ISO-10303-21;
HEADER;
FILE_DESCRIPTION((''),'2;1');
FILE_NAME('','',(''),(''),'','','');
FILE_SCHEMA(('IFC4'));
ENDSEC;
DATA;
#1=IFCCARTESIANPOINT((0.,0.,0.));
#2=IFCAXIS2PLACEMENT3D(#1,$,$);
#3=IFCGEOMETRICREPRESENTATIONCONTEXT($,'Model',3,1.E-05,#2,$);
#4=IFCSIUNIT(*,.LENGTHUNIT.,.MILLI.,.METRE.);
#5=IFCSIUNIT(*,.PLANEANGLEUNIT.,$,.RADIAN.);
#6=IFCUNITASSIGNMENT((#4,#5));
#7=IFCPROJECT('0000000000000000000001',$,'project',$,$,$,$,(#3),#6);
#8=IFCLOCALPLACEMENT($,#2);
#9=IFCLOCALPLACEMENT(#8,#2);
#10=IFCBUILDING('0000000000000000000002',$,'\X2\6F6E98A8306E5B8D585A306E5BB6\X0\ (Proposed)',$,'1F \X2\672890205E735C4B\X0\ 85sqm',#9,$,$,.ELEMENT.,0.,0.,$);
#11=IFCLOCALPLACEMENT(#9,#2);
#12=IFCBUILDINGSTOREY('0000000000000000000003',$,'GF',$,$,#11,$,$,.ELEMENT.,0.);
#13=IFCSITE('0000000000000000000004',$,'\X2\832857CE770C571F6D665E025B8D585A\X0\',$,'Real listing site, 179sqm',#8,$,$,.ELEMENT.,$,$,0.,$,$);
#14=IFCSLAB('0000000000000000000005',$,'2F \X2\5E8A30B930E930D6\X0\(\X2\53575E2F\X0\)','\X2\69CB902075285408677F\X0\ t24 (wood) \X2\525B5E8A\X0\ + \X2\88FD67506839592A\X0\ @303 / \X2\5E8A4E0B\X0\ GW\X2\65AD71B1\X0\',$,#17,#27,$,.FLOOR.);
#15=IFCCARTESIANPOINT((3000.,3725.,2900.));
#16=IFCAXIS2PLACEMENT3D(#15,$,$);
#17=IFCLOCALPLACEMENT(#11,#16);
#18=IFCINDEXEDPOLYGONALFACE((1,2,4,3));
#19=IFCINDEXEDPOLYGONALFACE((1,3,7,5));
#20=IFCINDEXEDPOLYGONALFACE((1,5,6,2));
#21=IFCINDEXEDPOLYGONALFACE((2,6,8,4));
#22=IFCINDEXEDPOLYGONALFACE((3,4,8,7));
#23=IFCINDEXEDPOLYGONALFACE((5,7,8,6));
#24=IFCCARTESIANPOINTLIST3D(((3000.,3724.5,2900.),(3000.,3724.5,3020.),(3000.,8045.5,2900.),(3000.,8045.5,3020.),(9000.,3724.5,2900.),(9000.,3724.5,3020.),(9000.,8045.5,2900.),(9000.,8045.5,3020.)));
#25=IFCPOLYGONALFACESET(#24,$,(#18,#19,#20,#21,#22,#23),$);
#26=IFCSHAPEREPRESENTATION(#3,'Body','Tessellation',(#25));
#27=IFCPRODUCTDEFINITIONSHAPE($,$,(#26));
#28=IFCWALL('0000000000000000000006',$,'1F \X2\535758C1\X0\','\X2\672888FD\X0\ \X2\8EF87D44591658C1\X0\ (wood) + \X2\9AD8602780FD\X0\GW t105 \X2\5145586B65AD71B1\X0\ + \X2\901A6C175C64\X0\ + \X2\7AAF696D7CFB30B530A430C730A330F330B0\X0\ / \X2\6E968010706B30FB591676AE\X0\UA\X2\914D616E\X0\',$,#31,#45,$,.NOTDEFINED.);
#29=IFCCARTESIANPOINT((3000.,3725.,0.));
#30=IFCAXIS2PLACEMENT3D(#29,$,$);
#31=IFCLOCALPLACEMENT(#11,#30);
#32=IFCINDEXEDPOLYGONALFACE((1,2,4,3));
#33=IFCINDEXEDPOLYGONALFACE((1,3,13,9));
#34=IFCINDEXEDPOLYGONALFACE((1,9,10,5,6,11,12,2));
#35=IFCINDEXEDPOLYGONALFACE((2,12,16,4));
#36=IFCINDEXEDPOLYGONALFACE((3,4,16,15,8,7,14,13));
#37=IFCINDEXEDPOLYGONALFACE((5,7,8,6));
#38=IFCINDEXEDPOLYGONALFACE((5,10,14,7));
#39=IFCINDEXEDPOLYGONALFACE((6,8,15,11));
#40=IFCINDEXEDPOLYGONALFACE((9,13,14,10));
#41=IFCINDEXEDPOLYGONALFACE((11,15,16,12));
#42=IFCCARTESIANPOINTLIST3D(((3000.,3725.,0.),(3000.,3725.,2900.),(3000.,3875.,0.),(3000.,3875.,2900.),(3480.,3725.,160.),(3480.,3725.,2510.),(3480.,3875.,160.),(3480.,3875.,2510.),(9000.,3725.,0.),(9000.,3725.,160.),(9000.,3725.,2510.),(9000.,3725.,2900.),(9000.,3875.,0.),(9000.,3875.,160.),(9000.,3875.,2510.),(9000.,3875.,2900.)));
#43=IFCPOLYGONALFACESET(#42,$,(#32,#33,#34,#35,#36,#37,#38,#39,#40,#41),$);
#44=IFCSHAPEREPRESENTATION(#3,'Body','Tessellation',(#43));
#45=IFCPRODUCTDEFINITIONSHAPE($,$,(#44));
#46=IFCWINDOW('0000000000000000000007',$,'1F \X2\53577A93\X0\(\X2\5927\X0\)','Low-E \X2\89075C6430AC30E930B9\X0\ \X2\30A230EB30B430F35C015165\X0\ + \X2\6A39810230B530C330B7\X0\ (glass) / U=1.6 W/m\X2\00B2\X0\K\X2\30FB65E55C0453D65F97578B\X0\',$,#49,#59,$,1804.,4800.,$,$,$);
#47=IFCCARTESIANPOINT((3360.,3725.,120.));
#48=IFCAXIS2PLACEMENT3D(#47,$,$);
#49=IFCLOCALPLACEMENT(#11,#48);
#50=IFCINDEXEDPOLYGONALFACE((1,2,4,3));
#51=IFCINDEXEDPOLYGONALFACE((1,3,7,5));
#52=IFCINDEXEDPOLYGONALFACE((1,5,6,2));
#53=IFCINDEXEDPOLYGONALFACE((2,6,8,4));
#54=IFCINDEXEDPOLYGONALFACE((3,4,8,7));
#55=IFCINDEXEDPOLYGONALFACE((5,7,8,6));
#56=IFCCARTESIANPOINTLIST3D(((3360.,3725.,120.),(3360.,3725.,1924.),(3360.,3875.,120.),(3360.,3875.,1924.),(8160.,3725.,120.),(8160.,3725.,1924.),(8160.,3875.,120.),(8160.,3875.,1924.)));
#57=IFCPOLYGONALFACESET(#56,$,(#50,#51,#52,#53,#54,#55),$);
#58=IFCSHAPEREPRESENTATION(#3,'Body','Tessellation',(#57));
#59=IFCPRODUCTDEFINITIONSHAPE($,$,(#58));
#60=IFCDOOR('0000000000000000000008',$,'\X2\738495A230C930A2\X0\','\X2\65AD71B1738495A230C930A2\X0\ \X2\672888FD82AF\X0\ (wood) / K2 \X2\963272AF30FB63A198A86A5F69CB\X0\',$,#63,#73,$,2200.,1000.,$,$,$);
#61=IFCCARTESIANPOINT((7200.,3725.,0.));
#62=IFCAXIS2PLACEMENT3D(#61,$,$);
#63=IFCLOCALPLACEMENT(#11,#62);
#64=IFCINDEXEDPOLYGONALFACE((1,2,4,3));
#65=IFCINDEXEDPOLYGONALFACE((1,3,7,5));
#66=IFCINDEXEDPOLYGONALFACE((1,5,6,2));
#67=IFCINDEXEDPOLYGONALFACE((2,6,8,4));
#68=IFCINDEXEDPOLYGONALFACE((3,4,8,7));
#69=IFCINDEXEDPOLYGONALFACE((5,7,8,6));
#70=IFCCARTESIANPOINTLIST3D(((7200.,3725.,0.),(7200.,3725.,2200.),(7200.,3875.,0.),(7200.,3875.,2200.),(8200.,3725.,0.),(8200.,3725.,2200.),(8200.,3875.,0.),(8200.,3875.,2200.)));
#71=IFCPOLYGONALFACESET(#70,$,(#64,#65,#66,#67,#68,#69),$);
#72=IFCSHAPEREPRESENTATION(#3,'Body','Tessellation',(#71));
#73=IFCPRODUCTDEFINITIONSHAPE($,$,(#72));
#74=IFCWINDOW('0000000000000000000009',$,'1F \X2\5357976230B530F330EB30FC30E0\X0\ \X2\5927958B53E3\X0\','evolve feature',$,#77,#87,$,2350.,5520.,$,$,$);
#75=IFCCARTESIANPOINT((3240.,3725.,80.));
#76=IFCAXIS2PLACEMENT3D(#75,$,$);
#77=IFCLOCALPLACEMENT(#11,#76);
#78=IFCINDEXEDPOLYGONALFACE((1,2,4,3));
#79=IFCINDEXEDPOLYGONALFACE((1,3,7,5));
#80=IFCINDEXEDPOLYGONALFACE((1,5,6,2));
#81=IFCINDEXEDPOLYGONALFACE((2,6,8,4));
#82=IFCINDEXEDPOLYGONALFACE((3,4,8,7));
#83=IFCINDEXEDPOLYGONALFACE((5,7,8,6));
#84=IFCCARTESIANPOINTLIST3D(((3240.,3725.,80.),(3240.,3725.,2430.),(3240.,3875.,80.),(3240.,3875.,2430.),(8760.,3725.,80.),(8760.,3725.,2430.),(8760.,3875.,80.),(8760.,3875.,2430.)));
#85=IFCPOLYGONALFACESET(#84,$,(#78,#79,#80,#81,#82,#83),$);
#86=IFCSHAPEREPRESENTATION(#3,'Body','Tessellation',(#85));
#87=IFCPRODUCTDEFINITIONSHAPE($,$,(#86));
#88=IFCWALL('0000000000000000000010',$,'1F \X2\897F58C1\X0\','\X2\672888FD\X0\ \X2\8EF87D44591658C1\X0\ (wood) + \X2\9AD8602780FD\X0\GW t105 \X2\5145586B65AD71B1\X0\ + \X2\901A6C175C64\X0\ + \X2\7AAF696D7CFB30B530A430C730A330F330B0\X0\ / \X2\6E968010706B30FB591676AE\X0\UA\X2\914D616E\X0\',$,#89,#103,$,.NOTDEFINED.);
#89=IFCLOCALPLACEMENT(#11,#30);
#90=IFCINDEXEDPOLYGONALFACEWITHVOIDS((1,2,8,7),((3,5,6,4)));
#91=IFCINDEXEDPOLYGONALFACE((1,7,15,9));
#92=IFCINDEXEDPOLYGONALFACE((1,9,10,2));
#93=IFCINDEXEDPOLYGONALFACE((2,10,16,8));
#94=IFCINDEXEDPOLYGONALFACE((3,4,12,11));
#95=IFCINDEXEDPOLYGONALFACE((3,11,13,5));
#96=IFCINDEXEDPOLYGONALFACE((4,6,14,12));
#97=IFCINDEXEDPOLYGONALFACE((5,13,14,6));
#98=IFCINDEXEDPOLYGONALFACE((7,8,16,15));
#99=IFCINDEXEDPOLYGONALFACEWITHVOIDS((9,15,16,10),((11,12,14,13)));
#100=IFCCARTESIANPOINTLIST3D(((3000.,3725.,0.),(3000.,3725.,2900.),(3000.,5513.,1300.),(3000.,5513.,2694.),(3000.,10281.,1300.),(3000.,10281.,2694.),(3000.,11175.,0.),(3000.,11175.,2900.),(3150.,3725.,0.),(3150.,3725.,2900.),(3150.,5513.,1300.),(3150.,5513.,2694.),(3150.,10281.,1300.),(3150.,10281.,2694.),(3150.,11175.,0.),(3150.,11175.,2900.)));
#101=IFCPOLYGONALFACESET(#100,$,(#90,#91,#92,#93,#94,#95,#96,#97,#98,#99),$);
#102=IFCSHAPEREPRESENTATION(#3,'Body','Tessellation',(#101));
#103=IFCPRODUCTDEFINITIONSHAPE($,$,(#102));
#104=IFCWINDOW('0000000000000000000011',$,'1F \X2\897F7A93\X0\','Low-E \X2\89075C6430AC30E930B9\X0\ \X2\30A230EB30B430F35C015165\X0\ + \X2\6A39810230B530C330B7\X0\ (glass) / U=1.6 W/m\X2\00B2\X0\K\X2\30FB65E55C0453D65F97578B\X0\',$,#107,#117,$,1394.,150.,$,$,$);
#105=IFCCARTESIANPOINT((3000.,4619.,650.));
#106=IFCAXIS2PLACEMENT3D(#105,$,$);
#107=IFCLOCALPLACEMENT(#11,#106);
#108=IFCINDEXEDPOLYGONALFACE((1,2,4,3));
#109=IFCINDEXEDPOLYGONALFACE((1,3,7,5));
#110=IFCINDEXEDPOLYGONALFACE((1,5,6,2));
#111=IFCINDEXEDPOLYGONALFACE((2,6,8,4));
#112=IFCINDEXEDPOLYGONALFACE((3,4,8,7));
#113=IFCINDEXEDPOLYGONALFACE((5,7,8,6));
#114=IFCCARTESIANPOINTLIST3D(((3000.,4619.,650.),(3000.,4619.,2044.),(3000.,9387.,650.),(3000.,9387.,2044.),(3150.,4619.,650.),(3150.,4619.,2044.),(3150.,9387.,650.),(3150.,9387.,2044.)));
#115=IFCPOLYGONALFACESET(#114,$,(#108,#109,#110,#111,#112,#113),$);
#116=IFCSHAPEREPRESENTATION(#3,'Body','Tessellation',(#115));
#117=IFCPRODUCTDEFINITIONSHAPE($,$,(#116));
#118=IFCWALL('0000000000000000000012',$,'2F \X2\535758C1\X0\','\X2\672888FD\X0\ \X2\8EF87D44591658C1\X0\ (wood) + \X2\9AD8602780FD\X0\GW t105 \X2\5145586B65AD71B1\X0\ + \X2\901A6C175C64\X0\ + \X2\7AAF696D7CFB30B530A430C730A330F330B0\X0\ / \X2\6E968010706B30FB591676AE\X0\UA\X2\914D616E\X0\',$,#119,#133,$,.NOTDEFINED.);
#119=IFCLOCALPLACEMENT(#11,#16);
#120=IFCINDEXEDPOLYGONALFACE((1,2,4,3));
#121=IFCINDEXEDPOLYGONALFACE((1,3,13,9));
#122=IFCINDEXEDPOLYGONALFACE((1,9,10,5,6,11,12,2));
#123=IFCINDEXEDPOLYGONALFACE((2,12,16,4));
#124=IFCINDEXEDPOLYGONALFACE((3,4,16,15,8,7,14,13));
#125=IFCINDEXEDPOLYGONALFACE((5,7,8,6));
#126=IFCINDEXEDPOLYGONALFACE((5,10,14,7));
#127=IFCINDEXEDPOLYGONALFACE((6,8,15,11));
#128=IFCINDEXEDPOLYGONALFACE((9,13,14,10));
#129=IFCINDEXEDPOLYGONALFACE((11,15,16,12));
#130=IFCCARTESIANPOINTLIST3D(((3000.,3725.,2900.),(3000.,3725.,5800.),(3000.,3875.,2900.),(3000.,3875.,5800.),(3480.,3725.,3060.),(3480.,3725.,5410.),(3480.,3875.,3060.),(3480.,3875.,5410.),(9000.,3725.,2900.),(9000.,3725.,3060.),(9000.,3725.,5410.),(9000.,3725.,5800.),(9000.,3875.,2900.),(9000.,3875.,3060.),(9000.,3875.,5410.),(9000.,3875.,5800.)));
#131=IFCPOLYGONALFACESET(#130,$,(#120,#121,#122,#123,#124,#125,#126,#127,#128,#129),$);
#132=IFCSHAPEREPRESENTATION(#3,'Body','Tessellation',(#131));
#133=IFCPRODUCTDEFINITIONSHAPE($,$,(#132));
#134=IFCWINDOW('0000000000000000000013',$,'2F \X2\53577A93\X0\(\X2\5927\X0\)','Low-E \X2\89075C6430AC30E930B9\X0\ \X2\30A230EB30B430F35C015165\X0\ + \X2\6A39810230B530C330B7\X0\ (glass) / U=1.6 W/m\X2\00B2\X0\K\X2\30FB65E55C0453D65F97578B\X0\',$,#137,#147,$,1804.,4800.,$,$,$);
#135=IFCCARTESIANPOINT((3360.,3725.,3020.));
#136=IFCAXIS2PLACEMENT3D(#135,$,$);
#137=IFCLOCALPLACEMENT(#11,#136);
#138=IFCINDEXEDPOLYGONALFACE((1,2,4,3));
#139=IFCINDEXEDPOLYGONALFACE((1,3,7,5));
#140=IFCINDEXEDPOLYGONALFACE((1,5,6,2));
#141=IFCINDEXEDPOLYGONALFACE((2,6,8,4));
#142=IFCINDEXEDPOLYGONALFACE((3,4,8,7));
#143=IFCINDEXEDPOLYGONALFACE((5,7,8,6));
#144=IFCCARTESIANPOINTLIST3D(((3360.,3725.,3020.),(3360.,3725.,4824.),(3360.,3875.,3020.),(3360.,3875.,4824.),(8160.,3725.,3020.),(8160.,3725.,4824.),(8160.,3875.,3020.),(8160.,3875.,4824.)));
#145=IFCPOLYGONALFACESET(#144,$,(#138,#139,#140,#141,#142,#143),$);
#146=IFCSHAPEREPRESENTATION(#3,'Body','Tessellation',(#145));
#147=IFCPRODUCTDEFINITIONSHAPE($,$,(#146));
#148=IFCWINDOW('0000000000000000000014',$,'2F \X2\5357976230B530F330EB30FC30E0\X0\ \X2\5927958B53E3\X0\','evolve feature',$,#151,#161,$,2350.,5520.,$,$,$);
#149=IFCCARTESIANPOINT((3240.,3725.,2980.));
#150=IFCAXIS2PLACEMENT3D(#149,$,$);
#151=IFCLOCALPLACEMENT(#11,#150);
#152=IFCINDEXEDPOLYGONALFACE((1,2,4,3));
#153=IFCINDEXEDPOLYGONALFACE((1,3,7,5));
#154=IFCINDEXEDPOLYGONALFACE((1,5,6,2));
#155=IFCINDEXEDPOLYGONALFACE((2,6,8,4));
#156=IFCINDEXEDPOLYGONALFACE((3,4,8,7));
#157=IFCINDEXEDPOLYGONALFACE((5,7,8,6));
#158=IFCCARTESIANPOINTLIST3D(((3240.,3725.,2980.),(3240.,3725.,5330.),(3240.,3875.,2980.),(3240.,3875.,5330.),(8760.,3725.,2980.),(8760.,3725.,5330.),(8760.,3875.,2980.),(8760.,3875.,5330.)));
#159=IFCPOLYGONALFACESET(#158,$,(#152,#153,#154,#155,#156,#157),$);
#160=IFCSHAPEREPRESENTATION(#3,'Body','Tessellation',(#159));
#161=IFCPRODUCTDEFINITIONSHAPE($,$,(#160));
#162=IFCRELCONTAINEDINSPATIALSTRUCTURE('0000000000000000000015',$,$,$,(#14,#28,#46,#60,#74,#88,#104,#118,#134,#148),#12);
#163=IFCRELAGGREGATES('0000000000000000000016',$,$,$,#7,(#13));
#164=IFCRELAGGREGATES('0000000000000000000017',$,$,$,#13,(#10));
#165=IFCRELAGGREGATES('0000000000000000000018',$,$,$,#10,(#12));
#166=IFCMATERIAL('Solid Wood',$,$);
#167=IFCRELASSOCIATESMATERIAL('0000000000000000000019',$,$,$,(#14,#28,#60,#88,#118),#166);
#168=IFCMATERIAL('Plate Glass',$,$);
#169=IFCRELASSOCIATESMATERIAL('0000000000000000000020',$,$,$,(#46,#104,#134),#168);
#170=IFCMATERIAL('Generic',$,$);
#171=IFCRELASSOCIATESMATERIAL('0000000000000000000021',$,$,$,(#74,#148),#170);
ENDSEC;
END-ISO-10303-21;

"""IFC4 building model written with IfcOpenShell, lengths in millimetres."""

from ifc_helpers import new_model, si_unit, frame, frame_2d, origin, place, context, project, spatial, rectangle, extrude, material, element, fill, save


model = new_model("IFC4")

# Units and contexts
model_context = context("Model", 3, precision=1e-05, world=origin())
ifc_project = project(units=[si_unit("LENGTHUNIT", "METRE", prefix="MILLI"), si_unit("PLANEANGLEUNIT", "RADIAN")], contexts=[model_context])

# Site, building, storey
site_placement = place(None, origin())
site = spatial("IfcSite", under=ifc_project, at=site_placement, Name="茨城県土浦市宍塚", ObjectType="Real listing site, 179sqm", CompositionType="ELEMENT", RefElevation=0.0)
building_placement = place(site_placement, origin())
building = spatial("IfcBuilding", under=site, at=building_placement, Name="潮風の宍塚の家 (Proposed)", ObjectType="1F 木造平屋 85sqm", CompositionType="ELEMENT", ElevationOfRefHeight=0.0, ElevationOfTerrain=0.0)
storey_placement = place(building_placement, origin())
storey = spatial("IfcBuildingStorey", under=building, at=storey_placement, Name="GF", CompositionType="ELEMENT", Elevation=0.0)

# Slab
ifc_material_1 = material(Name="Solid Wood")
slab_1_placement = place(storey_placement, frame((3000.0, 3725.0, 2900.0)))
element("IfcSlab", 1, at=slab_1_placement, inside=storey, material=ifc_material_1, Name="2F 床スラブ(南帯)", Description="構造用合板 t24 (wood) 剛床 + 製材根太 @303 / 床下 GW断熱", PredefinedType="FLOOR", context=model_context, shape_type="SweptSolid", body=[
    extrude(rectangle(XDim=6000.0, YDim=4321.0, at=frame_2d((3000.0, 2160.0))), frame((3000.0, 3725.0, 2900.0)), (0.0, 0.0, 1.0), 120.0),
])
ifc_material_2 = material(Name="Generic")

# Wall, openings, windows, door
wall_1_placement = place(storey_placement, frame((3000.0, 3725.0, 0.0)))
wall_1 = element("IfcWall", 2, at=wall_1_placement, inside=storey, material=ifc_material_1, Name="1F 南壁", Description="木製 軸組外壁 (wood) + 高性能GW t105 充填断熱 + 通気層 + 窯業系サイディング / 準耐火・外皮UA配慮", PredefinedType="NOTDEFINED", context=model_context, shape_type="SweptSolid", body=[
    extrude(rectangle(XDim=6000.0, YDim=150.0, at=frame_2d((3000.0, 75.0))), frame((3000.0, 3725.0, 0.0)), (0.0, 0.0, 1.0), 2900.0),
])
opening_1_placement = place(storey_placement, frame((3360.0, 3725.0, 120.0)))
opening_1 = element("IfcOpeningElement", 3, at=opening_1_placement, cuts=wall_1, PredefinedType="NOTDEFINED", context=model_context, shape_type="SweptSolid", body=[
    extrude(rectangle(XDim=4800.0, YDim=150.0, at=frame_2d((2400.0, 75.0))), frame((3360.0, 3725.0, 120.0)), (0.0, 0.0, 1.0), 1804.0),
])
opening_2_placement = place(storey_placement, frame((7200.0, 3725.0, 0.0)))
opening_2 = element("IfcOpeningElement", 4, at=opening_2_placement, cuts=wall_1, PredefinedType="NOTDEFINED", context=model_context, shape_type="SweptSolid", body=[
    extrude(rectangle(XDim=1000.0, YDim=150.0, at=frame_2d((500.0, 75.0))), frame((7200.0, 3725.0, 0.0)), (0.0, 0.0, 1.0), 2200.0),
])
opening_3_placement = place(storey_placement, frame((3240.0, 3725.0, 80.0)))
opening_3 = element("IfcOpeningElement", 5, at=opening_3_placement, cuts=wall_1, PredefinedType="NOTDEFINED", context=model_context, shape_type="SweptSolid", body=[
    extrude(rectangle(XDim=5520.0, YDim=150.0, at=frame_2d((2760.0, 75.0))), frame((3240.0, 3725.0, 80.0)), (0.0, 0.0, 1.0), 2350.0),
])
ifc_material_3 = material(Name="Plate Glass")
window_1_placement = place(storey_placement, frame((3360.0, 3725.0, 120.0)))
window_1 = element("IfcWindow", 6, at=window_1_placement, inside=storey, material=ifc_material_3, Name="1F 南窓(大)", Description="Low-E 複層ガラス アルゴン封入 + 樹脂サッシ (glass) / U=1.6 W/m²K・日射取得型", OverallHeight=1804.0, OverallWidth=4800.0, context=model_context, shape_type="SweptSolid", body=[
    extrude(rectangle(XDim=4800.0, YDim=150.0, at=frame_2d((2400.0, 75.0))), frame((3360.0, 3725.0, 120.0)), (0.0, 0.0, 1.0), 1804.0),
])
fill(opening_1, window_1)
door_placement = place(storey_placement, frame((7200.0, 3725.0, 0.0)))
door = element("IfcDoor", 7, at=door_placement, inside=storey, material=ifc_material_1, Name="玄関ドア", Description="断熱玄関ドア 木製芯 (wood) / K2 防犯・採風機構", OverallHeight=2200.0, OverallWidth=1000.0, context=model_context, shape_type="SweptSolid", body=[
    extrude(rectangle(XDim=1000.0, YDim=150.0, at=frame_2d((500.0, 75.0))), frame((7200.0, 3725.0, 0.0)), (0.0, 0.0, 1.0), 2200.0),
])
fill(opening_2, door)
window_2_placement = place(storey_placement, frame((3240.0, 3725.0, 80.0)))
window_2 = element("IfcWindow", 8, at=window_2_placement, inside=storey, material=ifc_material_2, Name="1F 南面サンルーム 大開口", Description="evolve feature", OverallHeight=2350.0, OverallWidth=5520.0, context=model_context, shape_type="SweptSolid", body=[
    extrude(rectangle(XDim=5520.0, YDim=150.0, at=frame_2d((2760.0, 75.0))), frame((3240.0, 3725.0, 80.0)), (0.0, 0.0, 1.0), 2350.0),
])
fill(opening_3, window_2)

# Wall, opening, window
wall_2_placement = place(storey_placement, frame((3000.0, 3725.0, 0.0)))
wall_2 = element("IfcWall", 9, at=wall_2_placement, inside=storey, material=ifc_material_1, Name="1F 西壁", Description="木製 軸組外壁 (wood) + 高性能GW t105 充填断熱 + 通気層 + 窯業系サイディング / 準耐火・外皮UA配慮", PredefinedType="NOTDEFINED", context=model_context, shape_type="SweptSolid", body=[
    extrude(rectangle(XDim=150.0, YDim=7450.0, at=frame_2d((75.0, 3725.0))), frame((3000.0, 3725.0, 0.0)), (0.0, 0.0, 1.0), 2900.0),
])
opening_4_placement = place(storey_placement, frame((3000.0, 4619.0, 650.0)))
opening_4 = element("IfcOpeningElement", 10, at=opening_4_placement, cuts=wall_2, PredefinedType="NOTDEFINED", context=model_context, shape_type="SweptSolid", body=[
    extrude(rectangle(XDim=150.0, YDim=4768.0, at=frame_2d((75.0, 2384.0))), frame((3000.0, 4619.0, 650.0)), (0.0, 0.0, 1.0), 1394.0),
])
window_3_placement = place(storey_placement, frame((3000.0, 4619.0, 650.0)))
window_3 = element("IfcWindow", 11, at=window_3_placement, inside=storey, material=ifc_material_3, Name="1F 西窓", Description="Low-E 複層ガラス アルゴン封入 + 樹脂サッシ (glass) / U=1.6 W/m²K・日射取得型", OverallHeight=1394.0, OverallWidth=150.0, context=model_context, shape_type="SweptSolid", body=[
    extrude(rectangle(XDim=150.0, YDim=4768.0, at=frame_2d((75.0, 2384.0))), frame((3000.0, 4619.0, 650.0)), (0.0, 0.0, 1.0), 1394.0),
])
fill(opening_4, window_3)

# Wall, openings, windows
wall_3_placement = place(storey_placement, frame((3000.0, 3725.0, 2900.0)))
wall_3 = element("IfcWall", 12, at=wall_3_placement, inside=storey, material=ifc_material_1, Name="2F 南壁", Description="木製 軸組外壁 (wood) + 高性能GW t105 充填断熱 + 通気層 + 窯業系サイディング / 準耐火・外皮UA配慮", PredefinedType="NOTDEFINED", context=model_context, shape_type="SweptSolid", body=[
    extrude(rectangle(XDim=6000.0, YDim=150.0, at=frame_2d((3000.0, 75.0))), frame((3000.0, 3725.0, 2900.0)), (0.0, 0.0, 1.0), 2900.0),
])
opening_5_placement = place(storey_placement, frame((3360.0, 3725.0, 3020.0)))
opening_5 = element("IfcOpeningElement", 13, at=opening_5_placement, cuts=wall_3, PredefinedType="NOTDEFINED", context=model_context, shape_type="SweptSolid", body=[
    extrude(rectangle(XDim=4800.0, YDim=150.0, at=frame_2d((2400.0, 75.0))), frame((3360.0, 3725.0, 3020.0)), (0.0, 0.0, 1.0), 1804.0),
])
opening_6_placement = place(storey_placement, frame((3240.0, 3725.0, 2980.0)))
opening_6 = element("IfcOpeningElement", 14, at=opening_6_placement, cuts=wall_3, PredefinedType="NOTDEFINED", context=model_context, shape_type="SweptSolid", body=[
    extrude(rectangle(XDim=5520.0, YDim=150.0, at=frame_2d((2760.0, 75.0))), frame((3240.0, 3725.0, 2980.0)), (0.0, 0.0, 1.0), 2350.0),
])
window_4_placement = place(storey_placement, frame((3360.0, 3725.0, 3020.0)))
window_4 = element("IfcWindow", 15, at=window_4_placement, inside=storey, material=ifc_material_3, Name="2F 南窓(大)", Description="Low-E 複層ガラス アルゴン封入 + 樹脂サッシ (glass) / U=1.6 W/m²K・日射取得型", OverallHeight=1804.0, OverallWidth=4800.0, context=model_context, shape_type="SweptSolid", body=[
    extrude(rectangle(XDim=4800.0, YDim=150.0, at=frame_2d((2400.0, 75.0))), frame((3360.0, 3725.0, 3020.0)), (0.0, 0.0, 1.0), 1804.0),
])
fill(opening_5, window_4)
window_5_placement = place(storey_placement, frame((3240.0, 3725.0, 2980.0)))
window_5 = element("IfcWindow", 16, at=window_5_placement, inside=storey, material=ifc_material_2, Name="2F 南面サンルーム 大開口", Description="evolve feature", OverallHeight=2350.0, OverallWidth=5520.0, context=model_context, shape_type="SweptSolid", body=[
    extrude(rectangle(XDim=5520.0, YDim=150.0, at=frame_2d((2760.0, 75.0))), frame((3240.0, 3725.0, 2980.0)), (0.0, 0.0, 1.0), 2350.0),
])
fill(opening_6, window_5)

save(model, "model.ifc")
